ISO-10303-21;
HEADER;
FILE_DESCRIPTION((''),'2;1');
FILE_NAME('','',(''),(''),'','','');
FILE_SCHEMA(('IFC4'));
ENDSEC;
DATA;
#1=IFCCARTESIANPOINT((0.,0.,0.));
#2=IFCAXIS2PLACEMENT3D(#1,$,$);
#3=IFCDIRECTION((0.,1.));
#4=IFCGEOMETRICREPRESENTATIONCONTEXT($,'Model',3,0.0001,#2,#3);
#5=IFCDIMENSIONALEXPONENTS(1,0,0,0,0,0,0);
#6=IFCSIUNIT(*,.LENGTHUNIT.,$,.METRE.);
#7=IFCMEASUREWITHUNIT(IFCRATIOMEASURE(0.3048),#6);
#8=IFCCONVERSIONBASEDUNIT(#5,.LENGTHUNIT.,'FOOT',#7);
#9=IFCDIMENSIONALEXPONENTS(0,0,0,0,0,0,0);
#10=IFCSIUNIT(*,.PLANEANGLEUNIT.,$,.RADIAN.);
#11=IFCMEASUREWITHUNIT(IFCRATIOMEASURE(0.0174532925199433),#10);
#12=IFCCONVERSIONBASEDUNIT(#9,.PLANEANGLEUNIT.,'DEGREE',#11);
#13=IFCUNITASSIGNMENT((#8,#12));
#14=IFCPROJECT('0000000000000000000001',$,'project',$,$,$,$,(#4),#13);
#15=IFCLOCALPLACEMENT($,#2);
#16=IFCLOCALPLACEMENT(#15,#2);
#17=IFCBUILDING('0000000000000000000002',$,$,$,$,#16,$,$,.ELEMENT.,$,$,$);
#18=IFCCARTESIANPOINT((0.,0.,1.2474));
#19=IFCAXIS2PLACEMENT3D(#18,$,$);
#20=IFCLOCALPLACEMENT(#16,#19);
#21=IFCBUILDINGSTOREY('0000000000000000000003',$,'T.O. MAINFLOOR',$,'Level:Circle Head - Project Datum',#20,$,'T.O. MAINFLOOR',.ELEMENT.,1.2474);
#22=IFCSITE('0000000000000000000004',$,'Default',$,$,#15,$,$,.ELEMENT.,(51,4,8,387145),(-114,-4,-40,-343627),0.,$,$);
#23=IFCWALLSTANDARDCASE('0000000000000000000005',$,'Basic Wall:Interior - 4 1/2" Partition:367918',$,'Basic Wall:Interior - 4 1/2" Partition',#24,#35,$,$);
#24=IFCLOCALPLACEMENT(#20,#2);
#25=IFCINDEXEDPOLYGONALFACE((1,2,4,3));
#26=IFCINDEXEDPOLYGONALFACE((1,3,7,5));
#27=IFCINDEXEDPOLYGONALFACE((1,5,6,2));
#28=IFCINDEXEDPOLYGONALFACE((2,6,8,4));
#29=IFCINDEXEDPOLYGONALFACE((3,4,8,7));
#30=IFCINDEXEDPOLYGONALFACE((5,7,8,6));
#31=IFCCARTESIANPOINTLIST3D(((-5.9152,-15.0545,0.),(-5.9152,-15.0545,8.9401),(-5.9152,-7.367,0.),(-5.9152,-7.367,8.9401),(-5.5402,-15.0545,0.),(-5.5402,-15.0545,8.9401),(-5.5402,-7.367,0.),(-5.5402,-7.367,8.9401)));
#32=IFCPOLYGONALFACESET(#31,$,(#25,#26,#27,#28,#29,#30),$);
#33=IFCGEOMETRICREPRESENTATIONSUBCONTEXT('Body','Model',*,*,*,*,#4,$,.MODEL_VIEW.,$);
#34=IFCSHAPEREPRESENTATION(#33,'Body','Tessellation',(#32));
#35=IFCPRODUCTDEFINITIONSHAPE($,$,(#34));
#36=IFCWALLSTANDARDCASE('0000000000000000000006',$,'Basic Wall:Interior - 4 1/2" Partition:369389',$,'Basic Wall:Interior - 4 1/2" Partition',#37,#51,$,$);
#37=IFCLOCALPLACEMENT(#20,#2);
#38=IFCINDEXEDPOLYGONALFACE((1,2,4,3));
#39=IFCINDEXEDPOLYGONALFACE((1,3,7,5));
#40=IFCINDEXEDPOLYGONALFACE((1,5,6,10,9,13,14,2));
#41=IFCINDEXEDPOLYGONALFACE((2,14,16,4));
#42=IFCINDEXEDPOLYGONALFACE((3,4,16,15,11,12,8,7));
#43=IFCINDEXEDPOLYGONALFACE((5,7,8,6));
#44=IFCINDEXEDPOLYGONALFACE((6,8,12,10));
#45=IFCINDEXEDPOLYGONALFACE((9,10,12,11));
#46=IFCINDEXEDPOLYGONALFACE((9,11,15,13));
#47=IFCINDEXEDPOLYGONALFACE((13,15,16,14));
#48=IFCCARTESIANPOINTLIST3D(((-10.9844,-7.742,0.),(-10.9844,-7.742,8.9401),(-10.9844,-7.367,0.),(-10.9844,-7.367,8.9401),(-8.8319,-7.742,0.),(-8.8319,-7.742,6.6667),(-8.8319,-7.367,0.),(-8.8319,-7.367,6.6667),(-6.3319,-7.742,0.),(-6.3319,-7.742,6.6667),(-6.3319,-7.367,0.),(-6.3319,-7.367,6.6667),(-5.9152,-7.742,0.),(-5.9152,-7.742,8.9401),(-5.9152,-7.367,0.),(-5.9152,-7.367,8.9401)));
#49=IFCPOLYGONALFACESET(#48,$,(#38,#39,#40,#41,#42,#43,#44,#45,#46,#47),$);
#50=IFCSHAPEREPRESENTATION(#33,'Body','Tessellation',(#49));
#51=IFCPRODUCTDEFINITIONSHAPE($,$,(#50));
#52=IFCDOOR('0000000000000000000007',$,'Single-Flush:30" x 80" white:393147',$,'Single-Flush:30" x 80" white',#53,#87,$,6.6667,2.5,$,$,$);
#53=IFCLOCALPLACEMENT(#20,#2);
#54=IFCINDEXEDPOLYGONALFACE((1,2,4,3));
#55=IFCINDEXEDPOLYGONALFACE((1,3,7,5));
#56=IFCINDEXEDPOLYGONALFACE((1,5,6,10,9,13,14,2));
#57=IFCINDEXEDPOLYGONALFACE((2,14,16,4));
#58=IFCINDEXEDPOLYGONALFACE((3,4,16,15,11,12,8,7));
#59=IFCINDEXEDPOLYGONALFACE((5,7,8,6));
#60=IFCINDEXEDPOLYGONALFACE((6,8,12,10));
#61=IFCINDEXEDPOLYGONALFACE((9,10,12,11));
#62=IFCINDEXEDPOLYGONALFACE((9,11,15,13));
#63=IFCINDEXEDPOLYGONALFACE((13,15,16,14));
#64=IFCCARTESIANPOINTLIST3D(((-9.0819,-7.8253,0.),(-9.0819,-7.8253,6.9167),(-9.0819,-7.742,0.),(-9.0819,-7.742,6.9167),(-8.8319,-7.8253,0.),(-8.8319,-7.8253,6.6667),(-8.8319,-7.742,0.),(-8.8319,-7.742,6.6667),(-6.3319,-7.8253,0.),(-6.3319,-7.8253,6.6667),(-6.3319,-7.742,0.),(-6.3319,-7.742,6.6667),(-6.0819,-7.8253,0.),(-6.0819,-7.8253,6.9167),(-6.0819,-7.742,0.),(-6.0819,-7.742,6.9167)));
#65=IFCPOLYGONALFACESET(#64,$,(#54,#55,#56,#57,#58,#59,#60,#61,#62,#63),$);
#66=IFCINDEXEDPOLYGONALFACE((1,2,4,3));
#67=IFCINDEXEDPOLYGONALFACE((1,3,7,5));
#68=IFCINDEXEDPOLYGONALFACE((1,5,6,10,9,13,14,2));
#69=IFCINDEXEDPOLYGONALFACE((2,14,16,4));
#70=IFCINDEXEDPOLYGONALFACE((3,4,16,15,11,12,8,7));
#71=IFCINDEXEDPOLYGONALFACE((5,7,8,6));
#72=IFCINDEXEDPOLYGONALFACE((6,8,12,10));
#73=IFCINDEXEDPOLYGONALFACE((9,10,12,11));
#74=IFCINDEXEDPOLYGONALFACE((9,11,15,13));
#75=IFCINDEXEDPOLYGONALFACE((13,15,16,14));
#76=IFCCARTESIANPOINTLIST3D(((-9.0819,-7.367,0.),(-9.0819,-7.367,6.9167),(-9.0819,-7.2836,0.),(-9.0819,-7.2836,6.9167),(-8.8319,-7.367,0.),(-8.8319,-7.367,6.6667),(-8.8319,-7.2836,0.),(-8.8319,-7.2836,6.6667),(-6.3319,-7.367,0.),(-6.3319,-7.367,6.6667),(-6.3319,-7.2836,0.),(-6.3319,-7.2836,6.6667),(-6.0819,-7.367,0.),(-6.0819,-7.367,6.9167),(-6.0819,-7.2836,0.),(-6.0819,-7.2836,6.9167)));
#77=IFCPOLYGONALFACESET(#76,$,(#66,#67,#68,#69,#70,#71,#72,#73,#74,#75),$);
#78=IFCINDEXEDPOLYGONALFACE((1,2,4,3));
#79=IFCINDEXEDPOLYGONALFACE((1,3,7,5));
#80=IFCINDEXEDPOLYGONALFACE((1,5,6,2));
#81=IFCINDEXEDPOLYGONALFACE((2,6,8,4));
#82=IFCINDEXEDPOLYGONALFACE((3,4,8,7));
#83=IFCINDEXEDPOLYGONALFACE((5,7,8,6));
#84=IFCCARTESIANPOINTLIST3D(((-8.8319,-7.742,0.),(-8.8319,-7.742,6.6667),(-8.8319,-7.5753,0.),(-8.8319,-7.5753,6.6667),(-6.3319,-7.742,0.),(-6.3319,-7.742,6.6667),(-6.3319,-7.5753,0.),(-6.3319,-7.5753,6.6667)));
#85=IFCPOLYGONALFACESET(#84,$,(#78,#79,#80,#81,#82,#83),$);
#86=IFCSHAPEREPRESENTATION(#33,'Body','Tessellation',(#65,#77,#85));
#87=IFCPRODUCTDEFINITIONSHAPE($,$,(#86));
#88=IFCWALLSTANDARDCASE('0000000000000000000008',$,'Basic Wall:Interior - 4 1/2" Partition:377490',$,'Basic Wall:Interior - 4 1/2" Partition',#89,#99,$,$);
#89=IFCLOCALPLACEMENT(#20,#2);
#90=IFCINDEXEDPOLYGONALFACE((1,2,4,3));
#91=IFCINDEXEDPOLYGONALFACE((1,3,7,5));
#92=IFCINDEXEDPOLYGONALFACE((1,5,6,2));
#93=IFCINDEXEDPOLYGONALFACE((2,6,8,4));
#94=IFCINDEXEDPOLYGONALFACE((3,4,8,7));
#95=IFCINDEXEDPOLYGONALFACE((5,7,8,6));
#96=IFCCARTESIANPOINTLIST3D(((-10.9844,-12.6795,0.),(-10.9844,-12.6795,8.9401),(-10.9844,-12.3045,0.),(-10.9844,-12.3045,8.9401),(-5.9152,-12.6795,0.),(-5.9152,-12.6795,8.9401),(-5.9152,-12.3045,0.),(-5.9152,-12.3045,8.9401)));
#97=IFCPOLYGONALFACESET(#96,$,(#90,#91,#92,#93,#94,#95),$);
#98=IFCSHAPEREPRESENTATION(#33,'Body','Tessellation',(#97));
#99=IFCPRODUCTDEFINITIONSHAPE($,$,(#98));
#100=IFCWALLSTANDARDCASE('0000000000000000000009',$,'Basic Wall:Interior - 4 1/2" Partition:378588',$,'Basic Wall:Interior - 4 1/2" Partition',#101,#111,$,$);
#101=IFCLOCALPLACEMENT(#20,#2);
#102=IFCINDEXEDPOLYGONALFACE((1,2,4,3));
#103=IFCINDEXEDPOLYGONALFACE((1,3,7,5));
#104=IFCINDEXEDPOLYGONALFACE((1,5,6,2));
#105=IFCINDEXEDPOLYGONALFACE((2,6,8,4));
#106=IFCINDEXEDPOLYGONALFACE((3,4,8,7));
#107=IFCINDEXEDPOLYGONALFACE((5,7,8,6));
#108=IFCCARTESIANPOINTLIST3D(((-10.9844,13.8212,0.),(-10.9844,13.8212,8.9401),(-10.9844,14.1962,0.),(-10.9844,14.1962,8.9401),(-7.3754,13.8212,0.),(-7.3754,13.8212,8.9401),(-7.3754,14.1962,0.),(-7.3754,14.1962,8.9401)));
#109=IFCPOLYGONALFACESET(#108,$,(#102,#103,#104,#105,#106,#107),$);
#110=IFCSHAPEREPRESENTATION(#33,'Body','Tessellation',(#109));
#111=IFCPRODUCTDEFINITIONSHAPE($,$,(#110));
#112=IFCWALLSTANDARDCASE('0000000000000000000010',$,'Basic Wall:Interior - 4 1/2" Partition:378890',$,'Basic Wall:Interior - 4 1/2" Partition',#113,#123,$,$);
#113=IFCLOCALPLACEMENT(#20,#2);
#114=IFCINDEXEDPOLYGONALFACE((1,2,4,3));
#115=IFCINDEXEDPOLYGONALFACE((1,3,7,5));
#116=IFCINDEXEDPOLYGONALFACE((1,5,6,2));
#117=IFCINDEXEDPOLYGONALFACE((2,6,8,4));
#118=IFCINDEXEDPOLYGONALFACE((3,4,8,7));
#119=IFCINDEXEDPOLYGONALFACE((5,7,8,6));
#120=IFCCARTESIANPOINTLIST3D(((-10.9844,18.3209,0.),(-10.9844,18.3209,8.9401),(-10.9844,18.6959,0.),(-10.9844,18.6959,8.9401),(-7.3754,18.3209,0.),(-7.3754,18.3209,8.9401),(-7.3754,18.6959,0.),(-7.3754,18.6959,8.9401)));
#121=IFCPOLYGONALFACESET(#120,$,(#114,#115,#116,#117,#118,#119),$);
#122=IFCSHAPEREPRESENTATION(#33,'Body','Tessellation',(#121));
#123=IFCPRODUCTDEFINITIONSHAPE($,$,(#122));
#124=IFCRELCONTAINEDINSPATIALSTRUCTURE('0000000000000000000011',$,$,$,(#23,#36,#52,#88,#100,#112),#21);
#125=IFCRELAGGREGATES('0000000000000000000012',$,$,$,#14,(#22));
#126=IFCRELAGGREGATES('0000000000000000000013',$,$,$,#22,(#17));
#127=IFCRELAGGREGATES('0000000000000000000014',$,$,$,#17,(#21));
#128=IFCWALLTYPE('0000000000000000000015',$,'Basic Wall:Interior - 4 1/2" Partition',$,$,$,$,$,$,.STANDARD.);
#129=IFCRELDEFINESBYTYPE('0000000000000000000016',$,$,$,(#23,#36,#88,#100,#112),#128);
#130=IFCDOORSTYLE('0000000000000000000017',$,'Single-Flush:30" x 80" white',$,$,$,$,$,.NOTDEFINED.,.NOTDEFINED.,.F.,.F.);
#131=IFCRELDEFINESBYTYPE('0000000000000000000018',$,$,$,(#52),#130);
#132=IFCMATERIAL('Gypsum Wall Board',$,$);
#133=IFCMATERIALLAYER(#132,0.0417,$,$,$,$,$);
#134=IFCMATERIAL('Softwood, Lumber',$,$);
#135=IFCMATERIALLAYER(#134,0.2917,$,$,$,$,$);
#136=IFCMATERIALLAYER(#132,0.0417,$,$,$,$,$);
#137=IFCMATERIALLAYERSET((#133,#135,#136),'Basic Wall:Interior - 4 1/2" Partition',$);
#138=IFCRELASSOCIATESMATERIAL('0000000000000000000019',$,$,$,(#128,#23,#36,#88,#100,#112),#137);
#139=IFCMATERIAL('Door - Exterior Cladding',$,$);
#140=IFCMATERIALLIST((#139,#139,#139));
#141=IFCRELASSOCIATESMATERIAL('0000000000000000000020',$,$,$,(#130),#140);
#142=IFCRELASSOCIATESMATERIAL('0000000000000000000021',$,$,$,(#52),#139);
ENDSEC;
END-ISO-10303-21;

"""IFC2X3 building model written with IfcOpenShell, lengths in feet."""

from ifc_helpers import new_model, entity, si_unit, converted_unit, direction, frame, frame_2d, origin, origin_2d_with_axis, place, context, subcontext, project, spatial, polyline, rectangle, outline, extrude, source, transform, mapped, material, material_list, layer, layer_set, layer_usage, type_object, type_shapes, element, fill, save


model = new_model("IFC2X3")

# Units and contexts
model_context = context("Model", 3, precision=0.0001, world=origin(), true_north=direction((0.0, 1.0)))
body_context = subcontext(model_context, "Body", "Model", "MODEL_VIEW")
ifc_project = project(units=[converted_unit("LENGTHUNIT", "FOOT", entity("IfcRatioMeasure", 0.3048), si_unit("LENGTHUNIT", "METRE"), dimensions=[1, 0, 0, 0, 0, 0, 0]), converted_unit("PLANEANGLEUNIT", "DEGREE", entity("IfcRatioMeasure", 0.0174532925199433), si_unit("PLANEANGLEUNIT", "RADIAN"), dimensions=[0, 0, 0, 0, 0, 0, 0])], contexts=[model_context])

# Site, building, storey
site_placement = place(None, origin())
site = spatial("IfcSite", under=ifc_project, at=site_placement, Name="Default", CompositionType="ELEMENT", RefLatitude=(51, 4, 8, 387145), RefLongitude=(-114, -4, -40, -343627), RefElevation=0.0)
building_placement = place(site_placement, origin())
building = spatial("IfcBuilding", under=site, at=building_placement, CompositionType="ELEMENT")
storey_placement = place(building_placement, frame((0.0, 0.0, 1.2474)))
storey = spatial("IfcBuildingStorey", under=building, at=storey_placement, Name="T.O. MAINFLOOR", ObjectType="Level:Circle Head - Project Datum", LongName="T.O. MAINFLOOR", CompositionType="ELEMENT", Elevation=1.2474)

# Shared definitions
ifc_material_1 = material(Name="Door - Exterior Cladding")

# Wall
ifc_material_2 = material(Name="Gypsum Wall Board")
ifc_layer_1 = layer(ifc_material_2, 0.0417)
ifc_material_3 = material(Name="Softwood, Lumber")
ifc_layer_2 = layer(ifc_material_3, 0.2917)
ifc_layer_3 = layer(ifc_material_2, 0.0417)
ifc_layer_set_1 = layer_set([ifc_layer_1, ifc_layer_2, ifc_layer_3], Name="Basic Wall:Interior - 4 1/2\" Partition")
ifc_layer_usage_1 = layer_usage(ifc_layer_set_1, "AXIS2", "NEGATIVE", 0.1875)
wall_type_1 = type_object("IfcWallType", Name="Basic Wall:Interior - 4 1/2\" Partition", PredefinedType="STANDARD", material=ifc_layer_set_1)
wall_1_placement = place(storey_placement, frame((-5.7277, -15.0545, 0.0), z_axis=(0.0, 0.0, 1.0), x_axis=(0.0, 1.0, 0.0)))
element("IfcWallStandardCase", 1, at=wall_1_placement, inside=storey, type_object=wall_type_1, material=ifc_layer_usage_1, Name="Basic Wall:Interior - 4 1/2\" Partition:367918", ObjectType="Basic Wall:Interior - 4 1/2\" Partition", context=body_context, shape_type="SweptSolid", body=[
    extrude(rectangle(XDim=7.6875, YDim=0.375, at=frame_2d((3.8438, 0.0), x_axis=(-1.0, 0.0))), origin(), (0.0, 0.0, 1.0), 8.9401),
])

# Wall, opening, door
ifc_layer_usage_2 = layer_usage(ifc_layer_set_1, "AXIS2", "NEGATIVE", 0.1875)
wall_2_placement = place(storey_placement, frame((-10.9844, -7.5545, 0.0)))
wall_2 = element("IfcWallStandardCase", 2, at=wall_2_placement, inside=storey, type_object=wall_type_1, material=ifc_layer_usage_2, Name="Basic Wall:Interior - 4 1/2\" Partition:369389", ObjectType="Basic Wall:Interior - 4 1/2\" Partition", context=body_context, shape_type="SweptSolid", body=[
    extrude(rectangle(XDim=5.0692, YDim=0.375, at=frame_2d((2.5346, 0.0), x_axis=(-1.0, 0.0))), origin(), (0.0, 0.0, 1.0), 8.9401),
])
opening_1_placement = place(wall_2_placement, frame((4.6525, 0.1875, 0.0)))
opening_1 = element("IfcOpeningElement", 3, at=opening_1_placement, cuts=wall_2, ObjectType="Opening", context=body_context, shape_type="SweptSolid", body=[
    extrude(rectangle(XDim=2.5, YDim=6.6667, at=frame_2d((3.3333, 1.25), x_axis=(0.0, -1.0))), frame((0.0, 0.0, 0.0), z_axis=(0.0, -1.0, 0.0), x_axis=(0.0, 0.0, 1.0)), (0.0, 0.0, 1.0), 0.375),
])
ifc_material_list_1 = material_list([ifc_material_1, ifc_material_1, ifc_material_1])
door_style_1 = type_object("IfcDoorStyle", Name="Single-Flush:30\" x 80\" white", ConstructionType="NOTDEFINED", OperationType="NOTDEFINED", ParameterTakesPrecedence=False, Sizeable=False, material=ifc_material_list_1)
shared_shape_1 = source(origin(), body_context, "Body", "SweptSolid", [
    extrude(outline(polyline([(-1.5, -3.5208), (1.5, -3.5208), (1.5, 3.3958), (1.25, 3.3958), (1.25, -3.2708), (-1.25, -3.2708), (-1.25, 3.3958), (-1.5, 3.3958), (-1.5, -3.5208)])), frame((1.25, 0.4583, 3.3958), z_axis=(0.0, -1.0, 0.0), x_axis=(-1.0, 0.0, 0.0)), (0.0, 0.0, 1.0), 0.0833),
    extrude(outline(polyline([(-3.5208, -1.5), (3.3958, -1.5), (3.3958, -1.25), (-3.2708, -1.25), (-3.2708, 1.25), (3.3958, 1.25), (3.3958, 1.5), (-3.5208, 1.5), (-3.5208, -1.5)])), frame((1.25, 0.0, 3.3958), z_axis=(0.0, -1.0, 0.0), x_axis=(0.0, 0.0, -1.0)), (0.0, 0.0, 1.0), 0.0833),
    extrude(rectangle(XDim=2.5, YDim=0.1667, at=origin_2d_with_axis()), frame((1.25, 0.2917, 0.0)), (0.0, 0.0, 1.0), 6.6667),
])
type_shapes(door_style_1, [shared_shape_1])
door_1_placement = place(opening_1_placement, frame((0.0, 0.0, 0.0), z_axis=(0.0, 0.0, 1.0), x_axis=(-1.0, 0.0, 0.0)))
door_1 = element("IfcDoor", 4, at=door_1_placement, inside=storey, type_object=door_style_1, material=ifc_material_1, Name="Single-Flush:30\" x 80\" white:393147", ObjectType="Single-Flush:30\" x 80\" white", OverallHeight=6.6667, OverallWidth=2.5, context=body_context, shape_type="MappedRepresentation", body=[
    mapped(shared_shape_1, transform((0.0, 0.0, 0.0), scale=1.0)),
])
fill(opening_1, door_1)

# Walls
ifc_layer_usage_3 = layer_usage(ifc_layer_set_1, "AXIS2", "NEGATIVE", 0.1875)
wall_3_placement = place(storey_placement, frame((-10.9844, -12.492, 0.0)))
element("IfcWallStandardCase", 5, at=wall_3_placement, inside=storey, type_object=wall_type_1, material=ifc_layer_usage_3, Name="Basic Wall:Interior - 4 1/2\" Partition:377490", ObjectType="Basic Wall:Interior - 4 1/2\" Partition", context=body_context, shape_type="SweptSolid", body=[
    extrude(rectangle(XDim=5.0692, YDim=0.375, at=frame_2d((2.5346, 0.0), x_axis=(-1.0, 0.0))), origin(), (0.0, 0.0, 1.0), 8.9401),
])
ifc_layer_usage_4 = layer_usage(ifc_layer_set_1, "AXIS2", "NEGATIVE", 0.1875)
wall_4_placement = place(storey_placement, frame((-10.9844, 14.0087, 0.0)))
element("IfcWallStandardCase", 6, at=wall_4_placement, inside=storey, type_object=wall_type_1, material=ifc_layer_usage_4, Name="Basic Wall:Interior - 4 1/2\" Partition:378588", ObjectType="Basic Wall:Interior - 4 1/2\" Partition", context=body_context, shape_type="SweptSolid", body=[
    extrude(rectangle(XDim=3.609, YDim=0.375, at=frame_2d((1.8045, 0.0), x_axis=(-1.0, 0.0))), origin(), (0.0, 0.0, 1.0), 8.9401),
])
ifc_layer_usage_5 = layer_usage(ifc_layer_set_1, "AXIS2", "NEGATIVE", 0.1875)
wall_5_placement = place(storey_placement, frame((-10.9844, 18.5084, 0.0)))
element("IfcWallStandardCase", 7, at=wall_5_placement, inside=storey, type_object=wall_type_1, material=ifc_layer_usage_5, Name="Basic Wall:Interior - 4 1/2\" Partition:378890", ObjectType="Basic Wall:Interior - 4 1/2\" Partition", context=body_context, shape_type="SweptSolid", body=[
    extrude(rectangle(XDim=3.609, YDim=0.375, at=frame_2d((1.8045, 0.0), x_axis=(-1.0, 0.0))), origin(), (0.0, 0.0, 1.0), 8.9401),
])

save(model, "model.ifc")
